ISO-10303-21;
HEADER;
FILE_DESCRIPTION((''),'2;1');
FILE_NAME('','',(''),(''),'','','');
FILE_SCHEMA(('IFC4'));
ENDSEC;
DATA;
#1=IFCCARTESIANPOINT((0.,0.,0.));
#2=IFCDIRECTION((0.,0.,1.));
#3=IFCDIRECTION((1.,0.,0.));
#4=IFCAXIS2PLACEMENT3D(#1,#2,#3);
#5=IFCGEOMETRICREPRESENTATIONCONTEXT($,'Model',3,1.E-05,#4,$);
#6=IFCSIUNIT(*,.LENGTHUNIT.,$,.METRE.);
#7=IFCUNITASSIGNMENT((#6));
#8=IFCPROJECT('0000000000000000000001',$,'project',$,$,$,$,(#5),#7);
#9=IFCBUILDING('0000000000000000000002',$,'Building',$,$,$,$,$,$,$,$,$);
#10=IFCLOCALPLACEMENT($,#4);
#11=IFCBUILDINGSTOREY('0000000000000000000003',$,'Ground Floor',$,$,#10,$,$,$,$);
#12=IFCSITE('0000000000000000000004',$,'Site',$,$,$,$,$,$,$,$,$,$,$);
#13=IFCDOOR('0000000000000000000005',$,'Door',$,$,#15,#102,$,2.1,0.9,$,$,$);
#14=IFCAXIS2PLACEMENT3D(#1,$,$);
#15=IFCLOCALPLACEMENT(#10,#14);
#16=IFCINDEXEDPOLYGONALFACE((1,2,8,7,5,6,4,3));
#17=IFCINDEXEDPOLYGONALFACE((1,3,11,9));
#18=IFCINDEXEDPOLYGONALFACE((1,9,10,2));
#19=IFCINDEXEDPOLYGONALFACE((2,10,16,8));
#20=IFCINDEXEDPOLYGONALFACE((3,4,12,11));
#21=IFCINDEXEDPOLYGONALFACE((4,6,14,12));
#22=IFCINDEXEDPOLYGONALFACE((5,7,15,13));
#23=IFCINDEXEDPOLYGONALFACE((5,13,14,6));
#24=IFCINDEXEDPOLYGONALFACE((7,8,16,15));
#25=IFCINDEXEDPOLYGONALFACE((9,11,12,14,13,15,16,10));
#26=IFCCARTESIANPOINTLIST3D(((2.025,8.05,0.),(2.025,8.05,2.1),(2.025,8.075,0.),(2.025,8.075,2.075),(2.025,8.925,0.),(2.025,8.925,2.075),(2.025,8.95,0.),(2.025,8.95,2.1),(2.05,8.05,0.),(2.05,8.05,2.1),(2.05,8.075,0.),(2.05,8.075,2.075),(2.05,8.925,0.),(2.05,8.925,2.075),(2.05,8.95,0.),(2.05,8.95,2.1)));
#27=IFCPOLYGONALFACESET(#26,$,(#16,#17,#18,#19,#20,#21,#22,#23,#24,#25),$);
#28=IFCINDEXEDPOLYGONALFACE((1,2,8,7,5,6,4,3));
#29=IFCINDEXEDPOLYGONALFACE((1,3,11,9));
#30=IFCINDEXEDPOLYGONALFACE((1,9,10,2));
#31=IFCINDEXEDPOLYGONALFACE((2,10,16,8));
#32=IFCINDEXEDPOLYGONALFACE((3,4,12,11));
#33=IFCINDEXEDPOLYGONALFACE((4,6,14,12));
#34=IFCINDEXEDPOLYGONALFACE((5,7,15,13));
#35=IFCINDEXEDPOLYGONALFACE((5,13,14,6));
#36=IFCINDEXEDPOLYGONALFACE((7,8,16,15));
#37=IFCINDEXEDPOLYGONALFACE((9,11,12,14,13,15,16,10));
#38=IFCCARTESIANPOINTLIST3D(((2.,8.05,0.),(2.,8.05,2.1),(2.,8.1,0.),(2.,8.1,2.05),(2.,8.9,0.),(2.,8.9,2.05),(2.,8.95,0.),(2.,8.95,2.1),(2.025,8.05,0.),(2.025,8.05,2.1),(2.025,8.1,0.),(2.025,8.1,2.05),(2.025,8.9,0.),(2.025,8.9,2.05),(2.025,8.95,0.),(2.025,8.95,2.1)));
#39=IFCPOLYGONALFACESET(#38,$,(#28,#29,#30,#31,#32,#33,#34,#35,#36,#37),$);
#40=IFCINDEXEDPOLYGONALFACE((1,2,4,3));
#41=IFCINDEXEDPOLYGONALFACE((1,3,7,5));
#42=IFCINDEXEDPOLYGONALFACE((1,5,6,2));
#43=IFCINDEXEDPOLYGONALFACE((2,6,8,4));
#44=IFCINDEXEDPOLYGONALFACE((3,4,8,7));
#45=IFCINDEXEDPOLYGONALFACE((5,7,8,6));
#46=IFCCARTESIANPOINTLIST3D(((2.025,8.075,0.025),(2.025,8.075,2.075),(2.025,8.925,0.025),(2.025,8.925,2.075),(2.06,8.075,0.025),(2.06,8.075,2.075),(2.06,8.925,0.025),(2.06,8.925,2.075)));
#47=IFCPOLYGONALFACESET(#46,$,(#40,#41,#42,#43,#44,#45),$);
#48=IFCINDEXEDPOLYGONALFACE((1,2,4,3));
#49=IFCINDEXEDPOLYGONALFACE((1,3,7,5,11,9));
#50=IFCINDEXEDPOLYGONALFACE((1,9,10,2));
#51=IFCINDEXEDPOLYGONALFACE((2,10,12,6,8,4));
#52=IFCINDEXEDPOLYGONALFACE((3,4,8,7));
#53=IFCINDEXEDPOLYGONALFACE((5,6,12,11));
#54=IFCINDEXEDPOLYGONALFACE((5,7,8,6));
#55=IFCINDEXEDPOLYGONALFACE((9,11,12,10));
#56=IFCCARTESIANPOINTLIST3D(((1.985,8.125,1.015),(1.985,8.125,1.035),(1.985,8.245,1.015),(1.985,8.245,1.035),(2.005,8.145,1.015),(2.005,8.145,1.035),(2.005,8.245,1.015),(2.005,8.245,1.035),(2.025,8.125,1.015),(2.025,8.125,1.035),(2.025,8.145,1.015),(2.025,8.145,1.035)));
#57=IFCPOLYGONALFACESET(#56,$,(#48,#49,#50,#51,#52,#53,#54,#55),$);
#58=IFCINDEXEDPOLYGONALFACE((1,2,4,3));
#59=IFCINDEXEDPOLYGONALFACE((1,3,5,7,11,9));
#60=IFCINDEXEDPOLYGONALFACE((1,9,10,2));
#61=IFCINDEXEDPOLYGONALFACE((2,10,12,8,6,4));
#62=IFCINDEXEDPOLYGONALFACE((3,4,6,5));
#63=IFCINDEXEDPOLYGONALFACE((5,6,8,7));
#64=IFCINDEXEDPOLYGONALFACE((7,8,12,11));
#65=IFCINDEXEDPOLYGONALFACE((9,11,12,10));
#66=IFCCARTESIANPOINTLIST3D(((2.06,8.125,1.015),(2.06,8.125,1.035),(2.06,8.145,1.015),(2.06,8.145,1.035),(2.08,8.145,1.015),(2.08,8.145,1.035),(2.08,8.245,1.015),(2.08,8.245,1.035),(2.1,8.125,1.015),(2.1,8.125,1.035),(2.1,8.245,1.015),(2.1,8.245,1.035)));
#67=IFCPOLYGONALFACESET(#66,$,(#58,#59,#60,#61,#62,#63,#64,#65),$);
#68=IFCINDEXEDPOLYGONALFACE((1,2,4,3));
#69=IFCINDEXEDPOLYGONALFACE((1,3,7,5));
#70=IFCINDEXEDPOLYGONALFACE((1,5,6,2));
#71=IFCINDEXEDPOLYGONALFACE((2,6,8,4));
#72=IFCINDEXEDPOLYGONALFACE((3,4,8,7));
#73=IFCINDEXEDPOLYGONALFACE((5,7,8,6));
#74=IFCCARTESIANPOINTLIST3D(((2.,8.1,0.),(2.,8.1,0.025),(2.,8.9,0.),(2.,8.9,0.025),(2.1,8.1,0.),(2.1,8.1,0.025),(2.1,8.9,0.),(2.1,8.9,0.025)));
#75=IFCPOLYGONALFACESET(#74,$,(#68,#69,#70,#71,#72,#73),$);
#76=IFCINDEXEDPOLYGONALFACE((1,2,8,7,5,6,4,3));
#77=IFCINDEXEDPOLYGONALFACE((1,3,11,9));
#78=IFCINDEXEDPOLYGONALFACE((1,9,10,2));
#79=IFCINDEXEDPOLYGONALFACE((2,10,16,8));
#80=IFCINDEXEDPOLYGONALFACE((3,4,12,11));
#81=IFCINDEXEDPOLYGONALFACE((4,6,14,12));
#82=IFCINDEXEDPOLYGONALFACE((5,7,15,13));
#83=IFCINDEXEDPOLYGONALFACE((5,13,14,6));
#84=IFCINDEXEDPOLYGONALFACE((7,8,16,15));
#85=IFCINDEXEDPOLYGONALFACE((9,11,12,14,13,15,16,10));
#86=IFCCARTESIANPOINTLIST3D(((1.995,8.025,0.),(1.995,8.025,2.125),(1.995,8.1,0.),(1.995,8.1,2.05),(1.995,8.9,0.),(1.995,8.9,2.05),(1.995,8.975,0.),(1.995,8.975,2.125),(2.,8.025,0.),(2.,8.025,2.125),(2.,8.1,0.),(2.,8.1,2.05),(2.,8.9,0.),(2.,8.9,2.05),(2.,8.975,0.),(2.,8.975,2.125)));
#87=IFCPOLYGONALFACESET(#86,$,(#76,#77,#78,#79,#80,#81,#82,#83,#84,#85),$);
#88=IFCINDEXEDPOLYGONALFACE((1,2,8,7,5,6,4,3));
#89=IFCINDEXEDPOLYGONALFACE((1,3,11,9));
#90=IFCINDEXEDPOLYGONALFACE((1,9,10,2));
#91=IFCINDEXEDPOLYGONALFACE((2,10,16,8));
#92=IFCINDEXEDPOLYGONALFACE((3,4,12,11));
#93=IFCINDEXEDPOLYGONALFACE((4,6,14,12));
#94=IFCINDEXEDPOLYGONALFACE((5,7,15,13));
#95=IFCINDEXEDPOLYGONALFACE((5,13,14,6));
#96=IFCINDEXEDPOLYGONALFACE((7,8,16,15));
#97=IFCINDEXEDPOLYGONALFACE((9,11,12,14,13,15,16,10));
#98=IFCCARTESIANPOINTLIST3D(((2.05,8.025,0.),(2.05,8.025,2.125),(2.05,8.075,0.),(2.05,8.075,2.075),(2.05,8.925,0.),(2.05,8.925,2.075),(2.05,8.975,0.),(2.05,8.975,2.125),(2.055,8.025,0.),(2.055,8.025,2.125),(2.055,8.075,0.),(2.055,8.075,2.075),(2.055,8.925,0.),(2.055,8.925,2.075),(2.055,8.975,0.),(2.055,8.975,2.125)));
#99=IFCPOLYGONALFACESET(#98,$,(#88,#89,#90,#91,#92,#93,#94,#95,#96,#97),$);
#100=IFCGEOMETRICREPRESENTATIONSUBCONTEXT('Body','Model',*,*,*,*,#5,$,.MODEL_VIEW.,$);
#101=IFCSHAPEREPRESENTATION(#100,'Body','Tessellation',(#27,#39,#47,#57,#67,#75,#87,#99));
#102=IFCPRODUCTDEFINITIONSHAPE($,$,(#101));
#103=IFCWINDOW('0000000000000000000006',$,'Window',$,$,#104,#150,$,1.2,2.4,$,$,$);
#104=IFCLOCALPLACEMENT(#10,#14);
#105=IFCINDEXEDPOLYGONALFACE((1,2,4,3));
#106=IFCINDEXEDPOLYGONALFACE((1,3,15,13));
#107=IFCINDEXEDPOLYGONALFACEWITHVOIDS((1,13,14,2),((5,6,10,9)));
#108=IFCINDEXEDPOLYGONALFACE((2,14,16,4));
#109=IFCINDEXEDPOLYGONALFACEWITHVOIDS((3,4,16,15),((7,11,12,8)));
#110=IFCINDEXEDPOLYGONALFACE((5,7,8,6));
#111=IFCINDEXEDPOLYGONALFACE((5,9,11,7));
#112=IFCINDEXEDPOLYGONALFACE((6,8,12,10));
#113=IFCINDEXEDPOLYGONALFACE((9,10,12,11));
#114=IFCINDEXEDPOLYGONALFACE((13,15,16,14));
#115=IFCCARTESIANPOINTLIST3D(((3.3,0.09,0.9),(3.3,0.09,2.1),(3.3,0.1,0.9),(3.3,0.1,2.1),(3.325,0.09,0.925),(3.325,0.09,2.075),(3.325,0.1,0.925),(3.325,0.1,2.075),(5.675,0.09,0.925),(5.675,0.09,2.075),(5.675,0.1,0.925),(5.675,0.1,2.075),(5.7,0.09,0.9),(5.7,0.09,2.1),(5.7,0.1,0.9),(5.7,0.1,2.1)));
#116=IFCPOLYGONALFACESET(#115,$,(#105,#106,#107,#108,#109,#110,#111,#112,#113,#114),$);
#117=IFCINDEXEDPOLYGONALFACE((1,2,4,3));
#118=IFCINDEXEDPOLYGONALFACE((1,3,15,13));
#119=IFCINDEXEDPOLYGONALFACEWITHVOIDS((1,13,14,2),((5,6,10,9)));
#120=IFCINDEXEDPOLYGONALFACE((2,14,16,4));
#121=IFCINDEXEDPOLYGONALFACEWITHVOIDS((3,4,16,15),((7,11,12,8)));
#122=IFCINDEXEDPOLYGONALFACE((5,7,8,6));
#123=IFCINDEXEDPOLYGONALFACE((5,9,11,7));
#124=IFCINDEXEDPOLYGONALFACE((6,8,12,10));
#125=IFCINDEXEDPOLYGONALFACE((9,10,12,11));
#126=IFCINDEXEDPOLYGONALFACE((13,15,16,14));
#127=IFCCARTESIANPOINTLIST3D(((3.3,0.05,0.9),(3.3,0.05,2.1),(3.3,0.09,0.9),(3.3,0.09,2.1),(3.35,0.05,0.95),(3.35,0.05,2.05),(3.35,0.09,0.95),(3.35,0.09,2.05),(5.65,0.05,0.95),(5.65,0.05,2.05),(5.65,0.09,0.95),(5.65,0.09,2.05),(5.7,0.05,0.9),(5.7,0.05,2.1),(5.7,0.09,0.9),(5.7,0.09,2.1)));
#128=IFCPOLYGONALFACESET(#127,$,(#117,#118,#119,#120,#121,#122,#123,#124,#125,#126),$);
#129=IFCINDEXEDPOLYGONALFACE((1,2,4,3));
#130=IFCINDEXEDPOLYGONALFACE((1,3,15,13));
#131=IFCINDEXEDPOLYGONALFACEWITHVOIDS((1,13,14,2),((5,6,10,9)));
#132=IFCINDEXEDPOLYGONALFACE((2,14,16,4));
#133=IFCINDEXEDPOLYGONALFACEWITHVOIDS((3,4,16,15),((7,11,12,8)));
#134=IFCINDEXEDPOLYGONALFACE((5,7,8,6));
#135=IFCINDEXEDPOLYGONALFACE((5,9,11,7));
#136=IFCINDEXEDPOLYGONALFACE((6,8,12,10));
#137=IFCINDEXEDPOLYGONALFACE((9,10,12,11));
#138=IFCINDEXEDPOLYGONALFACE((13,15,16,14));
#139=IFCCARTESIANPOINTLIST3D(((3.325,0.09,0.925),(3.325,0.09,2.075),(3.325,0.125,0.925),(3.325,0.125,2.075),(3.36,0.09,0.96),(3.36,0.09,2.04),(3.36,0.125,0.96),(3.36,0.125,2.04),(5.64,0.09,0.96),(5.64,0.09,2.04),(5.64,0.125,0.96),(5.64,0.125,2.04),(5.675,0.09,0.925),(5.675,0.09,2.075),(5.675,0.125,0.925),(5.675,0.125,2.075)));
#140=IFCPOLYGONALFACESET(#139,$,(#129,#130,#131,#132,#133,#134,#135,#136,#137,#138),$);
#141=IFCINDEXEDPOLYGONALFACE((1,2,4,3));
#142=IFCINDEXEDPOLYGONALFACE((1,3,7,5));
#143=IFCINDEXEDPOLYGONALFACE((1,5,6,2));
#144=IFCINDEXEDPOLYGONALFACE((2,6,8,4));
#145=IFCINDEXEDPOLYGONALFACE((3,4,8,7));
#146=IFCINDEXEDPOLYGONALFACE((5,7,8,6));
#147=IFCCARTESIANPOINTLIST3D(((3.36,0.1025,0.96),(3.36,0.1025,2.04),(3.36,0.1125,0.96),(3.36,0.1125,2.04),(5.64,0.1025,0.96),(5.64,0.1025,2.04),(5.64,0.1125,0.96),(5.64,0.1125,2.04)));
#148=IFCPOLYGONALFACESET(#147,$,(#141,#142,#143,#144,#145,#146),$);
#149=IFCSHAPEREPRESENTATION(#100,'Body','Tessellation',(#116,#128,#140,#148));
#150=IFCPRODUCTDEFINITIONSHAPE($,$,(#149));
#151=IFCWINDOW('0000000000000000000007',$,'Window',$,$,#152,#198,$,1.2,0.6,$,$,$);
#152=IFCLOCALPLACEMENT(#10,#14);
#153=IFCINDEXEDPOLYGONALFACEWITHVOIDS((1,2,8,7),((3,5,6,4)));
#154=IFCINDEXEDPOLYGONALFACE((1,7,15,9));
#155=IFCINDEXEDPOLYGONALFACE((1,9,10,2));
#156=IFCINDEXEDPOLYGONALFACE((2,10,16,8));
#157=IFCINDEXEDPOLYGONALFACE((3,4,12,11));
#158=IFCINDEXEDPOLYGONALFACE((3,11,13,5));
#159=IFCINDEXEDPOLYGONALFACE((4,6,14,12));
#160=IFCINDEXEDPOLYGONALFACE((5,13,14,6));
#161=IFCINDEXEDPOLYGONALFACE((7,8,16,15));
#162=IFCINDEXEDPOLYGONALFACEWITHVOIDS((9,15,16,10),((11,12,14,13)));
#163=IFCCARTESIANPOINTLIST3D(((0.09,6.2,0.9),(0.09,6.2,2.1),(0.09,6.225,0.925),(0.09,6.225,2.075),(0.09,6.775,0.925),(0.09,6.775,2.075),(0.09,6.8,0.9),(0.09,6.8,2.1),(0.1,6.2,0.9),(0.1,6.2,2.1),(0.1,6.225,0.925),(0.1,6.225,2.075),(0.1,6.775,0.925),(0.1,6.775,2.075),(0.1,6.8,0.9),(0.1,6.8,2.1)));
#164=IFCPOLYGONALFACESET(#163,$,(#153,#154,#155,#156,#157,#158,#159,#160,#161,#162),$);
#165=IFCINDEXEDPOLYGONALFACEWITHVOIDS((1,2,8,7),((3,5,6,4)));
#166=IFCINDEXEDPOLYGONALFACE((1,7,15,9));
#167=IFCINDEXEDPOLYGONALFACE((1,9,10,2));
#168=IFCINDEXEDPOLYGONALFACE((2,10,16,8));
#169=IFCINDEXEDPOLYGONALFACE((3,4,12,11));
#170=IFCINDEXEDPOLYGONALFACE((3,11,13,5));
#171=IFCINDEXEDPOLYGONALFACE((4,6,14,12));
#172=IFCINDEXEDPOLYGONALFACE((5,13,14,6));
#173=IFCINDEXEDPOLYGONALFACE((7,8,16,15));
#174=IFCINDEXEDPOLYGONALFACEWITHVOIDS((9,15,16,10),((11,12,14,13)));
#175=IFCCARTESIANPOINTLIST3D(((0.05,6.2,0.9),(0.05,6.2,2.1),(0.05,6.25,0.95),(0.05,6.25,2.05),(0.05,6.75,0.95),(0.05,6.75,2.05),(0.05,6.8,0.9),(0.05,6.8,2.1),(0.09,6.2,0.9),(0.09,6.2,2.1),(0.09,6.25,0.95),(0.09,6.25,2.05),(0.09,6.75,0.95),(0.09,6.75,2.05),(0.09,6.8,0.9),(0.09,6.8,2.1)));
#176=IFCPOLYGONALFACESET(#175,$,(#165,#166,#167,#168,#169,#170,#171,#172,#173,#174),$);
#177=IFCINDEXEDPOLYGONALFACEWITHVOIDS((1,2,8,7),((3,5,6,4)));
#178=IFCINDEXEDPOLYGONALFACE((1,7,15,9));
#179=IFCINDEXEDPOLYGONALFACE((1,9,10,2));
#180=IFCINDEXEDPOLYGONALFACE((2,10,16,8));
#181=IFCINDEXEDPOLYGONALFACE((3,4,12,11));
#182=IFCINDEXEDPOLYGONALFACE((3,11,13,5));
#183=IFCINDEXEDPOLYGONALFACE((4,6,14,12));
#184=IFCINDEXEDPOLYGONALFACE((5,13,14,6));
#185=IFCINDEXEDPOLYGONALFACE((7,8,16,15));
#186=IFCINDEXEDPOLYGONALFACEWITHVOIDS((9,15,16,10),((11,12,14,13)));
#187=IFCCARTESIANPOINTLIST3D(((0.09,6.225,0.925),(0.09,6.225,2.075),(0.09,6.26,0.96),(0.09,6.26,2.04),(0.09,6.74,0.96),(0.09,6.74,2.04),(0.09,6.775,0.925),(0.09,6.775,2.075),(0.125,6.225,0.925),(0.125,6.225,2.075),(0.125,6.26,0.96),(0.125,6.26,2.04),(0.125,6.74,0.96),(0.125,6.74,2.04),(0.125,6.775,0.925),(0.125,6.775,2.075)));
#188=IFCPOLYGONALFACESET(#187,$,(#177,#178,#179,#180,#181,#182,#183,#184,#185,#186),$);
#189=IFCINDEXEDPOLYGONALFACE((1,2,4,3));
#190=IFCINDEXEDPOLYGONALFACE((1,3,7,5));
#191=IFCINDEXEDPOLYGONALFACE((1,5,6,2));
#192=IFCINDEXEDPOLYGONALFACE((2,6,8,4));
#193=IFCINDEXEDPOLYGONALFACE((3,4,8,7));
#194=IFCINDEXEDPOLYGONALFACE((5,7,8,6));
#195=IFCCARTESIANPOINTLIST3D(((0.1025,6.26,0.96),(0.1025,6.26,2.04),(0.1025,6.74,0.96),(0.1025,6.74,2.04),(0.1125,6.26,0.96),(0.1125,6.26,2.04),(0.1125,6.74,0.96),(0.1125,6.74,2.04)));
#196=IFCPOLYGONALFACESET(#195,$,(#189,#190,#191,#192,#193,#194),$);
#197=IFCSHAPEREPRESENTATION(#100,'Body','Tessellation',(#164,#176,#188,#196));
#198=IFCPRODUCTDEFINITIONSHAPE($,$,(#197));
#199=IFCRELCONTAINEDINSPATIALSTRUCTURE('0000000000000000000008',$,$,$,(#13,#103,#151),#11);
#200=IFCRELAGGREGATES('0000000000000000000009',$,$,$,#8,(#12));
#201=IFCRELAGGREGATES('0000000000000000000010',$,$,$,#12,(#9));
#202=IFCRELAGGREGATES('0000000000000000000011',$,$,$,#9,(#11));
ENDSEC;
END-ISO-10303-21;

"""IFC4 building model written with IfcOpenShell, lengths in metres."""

from ifc_helpers import new_model, si_unit, frame, origin_with_axes, place, context, subcontext, project, spatial, line, indexed_curve, outline, extrude, element, save


model = new_model("IFC4")

# Units and contexts
model_context = context("Model", 3, precision=1e-05, world=origin_with_axes())
body_context = subcontext(model_context, "Body", "Model", "MODEL_VIEW")
ifc_project = project(units=[si_unit("LENGTHUNIT", "METRE")], contexts=[model_context])

# Site, building, storey
site = spatial("IfcSite", under=ifc_project, Name="Site")
building = spatial("IfcBuilding", under=site, Name="Building")
storey_placement = place(None, origin_with_axes())
storey = spatial("IfcBuildingStorey", under=building, at=storey_placement, Name="Ground Floor")

# Door
door_1_placement = place(storey_placement, frame((2.0, 8.95, 0.0), z_axis=(0.0, 0.0, 1.0), x_axis=(0.0, -1.0, 0.0)))
element("IfcDoor", 1, at=door_1_placement, inside=storey, Name="Door", OverallHeight=2.1, OverallWidth=0.9, context=body_context, shape_type="SweptSolid", body=[
    extrude(outline(indexed_curve([(0.0, 0.0), (0.0, 2.1), (0.9, 2.1), (0.9, 0.0), (0.875, 0.0), (0.875, 2.075), (0.025, 2.075), (0.025, 0.0)], segments=[line(1, 2, 3, 4, 5, 6, 7, 8, 1)])), frame((0.0, 0.025, 0.0), z_axis=(0.0, -1.0, 0.0), x_axis=(1.0, 0.0, 0.0)), (0.0, 0.0, -1.0), 0.025),
    extrude(outline(indexed_curve([(0.0, 0.0), (0.0, 2.1), (0.9, 2.1), (0.9, 0.0), (0.85, 0.0), (0.85, 2.05), (0.05, 2.05), (0.05, 0.0)], segments=[line(1, 2, 3, 4, 5, 6, 7, 8, 1)])), frame((0.0, 0.0, 0.0), z_axis=(0.0, -1.0, 0.0), x_axis=(1.0, 0.0, 0.0)), (0.0, 0.0, -1.0), 0.025),
    extrude(outline(indexed_curve([(0.0, 0.0), (0.85, 0.0), (0.85, 0.035), (0.0, 0.035)], segments=[line(1, 2, 3, 4, 1)])), frame((0.025, 0.025, 0.025), z_axis=(0.0, 0.0, 1.0), x_axis=(1.0, 0.0, 0.0)), (0.0, 0.0, 1.0), 2.05),
    extrude(outline(indexed_curve([(0.0, 0.0), (0.0, -0.04), (-0.12, -0.04), (-0.12, -0.02), (-0.02, -0.02), (-0.02, 0.0)], segments=[line(1, 2, 3, 4, 5, 6, 1)])), frame((0.825, 0.025, 1.015), z_axis=(0.0, 0.0, 1.0), x_axis=(1.0, 0.0, 0.0)), (0.0, 0.0, 1.0), 0.02),
    extrude(outline(indexed_curve([(0.0, 0.0), (0.0, 0.04), (-0.12, 0.04), (-0.12, 0.02), (-0.02, 0.02), (-0.02, 0.0)], segments=[line(1, 2, 3, 4, 5, 6, 1)])), frame((0.825, 0.06, 1.015), z_axis=(0.0, 0.0, 1.0), x_axis=(1.0, 0.0, 0.0)), (0.0, 0.0, 1.0), 0.02),
    extrude(outline(indexed_curve([(0.0, 0.0), (0.8, 0.0), (0.8, 0.1), (0.0, 0.1)], segments=[line(1, 2, 3, 4, 1)])), frame((0.05, 0.0, 0.0), z_axis=(0.0, 0.0, 1.0), x_axis=(1.0, 0.0, 0.0)), (0.0, 0.0, 1.0), 0.025),
    extrude(outline(indexed_curve([(0.0, 0.0), (0.0, 2.125), (0.95, 2.125), (0.95, 0.0), (0.875, 0.0), (0.875, 2.05), (0.075, 2.05), (0.075, 0.0)], segments=[line(1, 2, 3, 4, 5, 6, 7, 8, 1)])), frame((-0.025, -0.005, 0.0), z_axis=(0.0, -1.0, 0.0), x_axis=(1.0, 0.0, 0.0)), (0.0, 0.0, -1.0), 0.005),
    extrude(outline(indexed_curve([(0.0, 0.0), (0.0, 2.125), (0.95, 2.125), (0.95, 0.0), (0.9, 0.0), (0.9, 2.075), (0.05, 2.075), (0.05, 0.0)], segments=[line(1, 2, 3, 4, 5, 6, 7, 8, 1)])), frame((-0.025, 0.05, 0.0), z_axis=(0.0, -1.0, 0.0), x_axis=(1.0, 0.0, 0.0)), (0.0, 0.0, -1.0), 0.005),
])

# Windows
window_placement = place(storey_placement, frame((3.3, 0.0, 0.9), z_axis=(0.0, 0.0, 1.0), x_axis=(1.0, 0.0, 0.0)))
element("IfcWindow", 2, at=window_placement, inside=storey, Name="Window", OverallHeight=1.2, OverallWidth=2.4, context=body_context, shape_type="SweptSolid", body=[
    extrude(outline(indexed_curve([(0.0, 0.0), (2.4, 0.0), (2.4, 1.2), (0.0, 1.2)], segments=[line(1, 2, 3, 4, 1)]), holes=[indexed_curve([(0.025, 0.025), (2.375, 0.025), (2.375, 1.175), (0.025, 1.175)], segments=[line(1, 2, 3, 4, 1)])]), frame((0.0, 0.09, 0.0), z_axis=(0.0, -1.0, 0.0), x_axis=(1.0, 0.0, 0.0)), (0.0, 0.0, -1.0), 0.01),
    extrude(outline(indexed_curve([(0.0, 0.0), (2.4, 0.0), (2.4, 1.2), (0.0, 1.2)], segments=[line(1, 2, 3, 4, 1)]), holes=[indexed_curve([(0.05, 0.05), (2.35, 0.05), (2.35, 1.15), (0.05, 1.15)], segments=[line(1, 2, 3, 4, 1)])]), frame((0.0, 0.05, 0.0), z_axis=(0.0, -1.0, 0.0), x_axis=(1.0, 0.0, 0.0)), (0.0, 0.0, -1.0), 0.04),
    extrude(outline(indexed_curve([(0.0, 0.0), (2.35, 0.0), (2.35, 1.15), (0.0, 1.15)], segments=[line(1, 2, 3, 4, 1)]), holes=[indexed_curve([(0.035, 0.035), (2.315, 0.035), (2.315, 1.115), (0.035, 1.115)], segments=[line(1, 2, 3, 4, 1)])]), frame((0.025, 0.09, 0.025), z_axis=(0.0, -1.0, 0.0), x_axis=(1.0, 0.0, 0.0)), (0.0, 0.0, -1.0), 0.035),
    extrude(outline(indexed_curve([(0.035, 0.035), (2.315, 0.035), (2.315, 1.115), (0.035, 1.115)], segments=[line(1, 2, 3, 4, 1)])), frame((0.025, 0.1025, 0.025), z_axis=(0.0, -1.0, 0.0), x_axis=(1.0, 0.0, 0.0)), (0.0, 0.0, -1.0), 0.01),
])
for number, where, z_axis, x_axis, name in (
    (3, (0.0, 6.8, 0.9), (0.0, 0.0, 1.0), (0.0, -1.0, 0.0), "Window"),
):
    element("IfcWindow", number, at=place(storey_placement, frame(where, z_axis=z_axis, x_axis=x_axis)), inside=storey, Name=name, OverallHeight=1.2, OverallWidth=0.6, context=body_context, shape_type="SweptSolid", body=[
        extrude(outline(indexed_curve([(0.0, 0.0), (0.6, 0.0), (0.6, 1.2), (0.0, 1.2)], segments=[line(1, 2, 3, 4, 1)]), holes=[indexed_curve([(0.025, 0.025), (0.575, 0.025), (0.575, 1.175), (0.025, 1.175)], segments=[line(1, 2, 3, 4, 1)])]), frame((0.0, 0.09, 0.0), z_axis=(0.0, -1.0, 0.0), x_axis=(1.0, 0.0, 0.0)), (0.0, 0.0, -1.0), 0.01),
        extrude(outline(indexed_curve([(0.0, 0.0), (0.6, 0.0), (0.6, 1.2), (0.0, 1.2)], segments=[line(1, 2, 3, 4, 1)]), holes=[indexed_curve([(0.05, 0.05), (0.55, 0.05), (0.55, 1.15), (0.05, 1.15)], segments=[line(1, 2, 3, 4, 1)])]), frame((0.0, 0.05, 0.0), z_axis=(0.0, -1.0, 0.0), x_axis=(1.0, 0.0, 0.0)), (0.0, 0.0, -1.0), 0.04),
        extrude(outline(indexed_curve([(0.0, 0.0), (0.55, 0.0), (0.55, 1.15), (0.0, 1.15)], segments=[line(1, 2, 3, 4, 1)]), holes=[indexed_curve([(0.035, 0.035), (0.515, 0.035), (0.515, 1.115), (0.035, 1.115)], segments=[line(1, 2, 3, 4, 1)])]), frame((0.025, 0.09, 0.025), z_axis=(0.0, -1.0, 0.0), x_axis=(1.0, 0.0, 0.0)), (0.0, 0.0, -1.0), 0.035),
        extrude(outline(indexed_curve([(0.035, 0.035), (0.515, 0.035), (0.515, 1.115), (0.035, 1.115)], segments=[line(1, 2, 3, 4, 1)])), frame((0.025, 0.1025, 0.025), z_axis=(0.0, -1.0, 0.0), x_axis=(1.0, 0.0, 0.0)), (0.0, 0.0, -1.0), 0.01),
    ])

save(model, "model.ifc")
